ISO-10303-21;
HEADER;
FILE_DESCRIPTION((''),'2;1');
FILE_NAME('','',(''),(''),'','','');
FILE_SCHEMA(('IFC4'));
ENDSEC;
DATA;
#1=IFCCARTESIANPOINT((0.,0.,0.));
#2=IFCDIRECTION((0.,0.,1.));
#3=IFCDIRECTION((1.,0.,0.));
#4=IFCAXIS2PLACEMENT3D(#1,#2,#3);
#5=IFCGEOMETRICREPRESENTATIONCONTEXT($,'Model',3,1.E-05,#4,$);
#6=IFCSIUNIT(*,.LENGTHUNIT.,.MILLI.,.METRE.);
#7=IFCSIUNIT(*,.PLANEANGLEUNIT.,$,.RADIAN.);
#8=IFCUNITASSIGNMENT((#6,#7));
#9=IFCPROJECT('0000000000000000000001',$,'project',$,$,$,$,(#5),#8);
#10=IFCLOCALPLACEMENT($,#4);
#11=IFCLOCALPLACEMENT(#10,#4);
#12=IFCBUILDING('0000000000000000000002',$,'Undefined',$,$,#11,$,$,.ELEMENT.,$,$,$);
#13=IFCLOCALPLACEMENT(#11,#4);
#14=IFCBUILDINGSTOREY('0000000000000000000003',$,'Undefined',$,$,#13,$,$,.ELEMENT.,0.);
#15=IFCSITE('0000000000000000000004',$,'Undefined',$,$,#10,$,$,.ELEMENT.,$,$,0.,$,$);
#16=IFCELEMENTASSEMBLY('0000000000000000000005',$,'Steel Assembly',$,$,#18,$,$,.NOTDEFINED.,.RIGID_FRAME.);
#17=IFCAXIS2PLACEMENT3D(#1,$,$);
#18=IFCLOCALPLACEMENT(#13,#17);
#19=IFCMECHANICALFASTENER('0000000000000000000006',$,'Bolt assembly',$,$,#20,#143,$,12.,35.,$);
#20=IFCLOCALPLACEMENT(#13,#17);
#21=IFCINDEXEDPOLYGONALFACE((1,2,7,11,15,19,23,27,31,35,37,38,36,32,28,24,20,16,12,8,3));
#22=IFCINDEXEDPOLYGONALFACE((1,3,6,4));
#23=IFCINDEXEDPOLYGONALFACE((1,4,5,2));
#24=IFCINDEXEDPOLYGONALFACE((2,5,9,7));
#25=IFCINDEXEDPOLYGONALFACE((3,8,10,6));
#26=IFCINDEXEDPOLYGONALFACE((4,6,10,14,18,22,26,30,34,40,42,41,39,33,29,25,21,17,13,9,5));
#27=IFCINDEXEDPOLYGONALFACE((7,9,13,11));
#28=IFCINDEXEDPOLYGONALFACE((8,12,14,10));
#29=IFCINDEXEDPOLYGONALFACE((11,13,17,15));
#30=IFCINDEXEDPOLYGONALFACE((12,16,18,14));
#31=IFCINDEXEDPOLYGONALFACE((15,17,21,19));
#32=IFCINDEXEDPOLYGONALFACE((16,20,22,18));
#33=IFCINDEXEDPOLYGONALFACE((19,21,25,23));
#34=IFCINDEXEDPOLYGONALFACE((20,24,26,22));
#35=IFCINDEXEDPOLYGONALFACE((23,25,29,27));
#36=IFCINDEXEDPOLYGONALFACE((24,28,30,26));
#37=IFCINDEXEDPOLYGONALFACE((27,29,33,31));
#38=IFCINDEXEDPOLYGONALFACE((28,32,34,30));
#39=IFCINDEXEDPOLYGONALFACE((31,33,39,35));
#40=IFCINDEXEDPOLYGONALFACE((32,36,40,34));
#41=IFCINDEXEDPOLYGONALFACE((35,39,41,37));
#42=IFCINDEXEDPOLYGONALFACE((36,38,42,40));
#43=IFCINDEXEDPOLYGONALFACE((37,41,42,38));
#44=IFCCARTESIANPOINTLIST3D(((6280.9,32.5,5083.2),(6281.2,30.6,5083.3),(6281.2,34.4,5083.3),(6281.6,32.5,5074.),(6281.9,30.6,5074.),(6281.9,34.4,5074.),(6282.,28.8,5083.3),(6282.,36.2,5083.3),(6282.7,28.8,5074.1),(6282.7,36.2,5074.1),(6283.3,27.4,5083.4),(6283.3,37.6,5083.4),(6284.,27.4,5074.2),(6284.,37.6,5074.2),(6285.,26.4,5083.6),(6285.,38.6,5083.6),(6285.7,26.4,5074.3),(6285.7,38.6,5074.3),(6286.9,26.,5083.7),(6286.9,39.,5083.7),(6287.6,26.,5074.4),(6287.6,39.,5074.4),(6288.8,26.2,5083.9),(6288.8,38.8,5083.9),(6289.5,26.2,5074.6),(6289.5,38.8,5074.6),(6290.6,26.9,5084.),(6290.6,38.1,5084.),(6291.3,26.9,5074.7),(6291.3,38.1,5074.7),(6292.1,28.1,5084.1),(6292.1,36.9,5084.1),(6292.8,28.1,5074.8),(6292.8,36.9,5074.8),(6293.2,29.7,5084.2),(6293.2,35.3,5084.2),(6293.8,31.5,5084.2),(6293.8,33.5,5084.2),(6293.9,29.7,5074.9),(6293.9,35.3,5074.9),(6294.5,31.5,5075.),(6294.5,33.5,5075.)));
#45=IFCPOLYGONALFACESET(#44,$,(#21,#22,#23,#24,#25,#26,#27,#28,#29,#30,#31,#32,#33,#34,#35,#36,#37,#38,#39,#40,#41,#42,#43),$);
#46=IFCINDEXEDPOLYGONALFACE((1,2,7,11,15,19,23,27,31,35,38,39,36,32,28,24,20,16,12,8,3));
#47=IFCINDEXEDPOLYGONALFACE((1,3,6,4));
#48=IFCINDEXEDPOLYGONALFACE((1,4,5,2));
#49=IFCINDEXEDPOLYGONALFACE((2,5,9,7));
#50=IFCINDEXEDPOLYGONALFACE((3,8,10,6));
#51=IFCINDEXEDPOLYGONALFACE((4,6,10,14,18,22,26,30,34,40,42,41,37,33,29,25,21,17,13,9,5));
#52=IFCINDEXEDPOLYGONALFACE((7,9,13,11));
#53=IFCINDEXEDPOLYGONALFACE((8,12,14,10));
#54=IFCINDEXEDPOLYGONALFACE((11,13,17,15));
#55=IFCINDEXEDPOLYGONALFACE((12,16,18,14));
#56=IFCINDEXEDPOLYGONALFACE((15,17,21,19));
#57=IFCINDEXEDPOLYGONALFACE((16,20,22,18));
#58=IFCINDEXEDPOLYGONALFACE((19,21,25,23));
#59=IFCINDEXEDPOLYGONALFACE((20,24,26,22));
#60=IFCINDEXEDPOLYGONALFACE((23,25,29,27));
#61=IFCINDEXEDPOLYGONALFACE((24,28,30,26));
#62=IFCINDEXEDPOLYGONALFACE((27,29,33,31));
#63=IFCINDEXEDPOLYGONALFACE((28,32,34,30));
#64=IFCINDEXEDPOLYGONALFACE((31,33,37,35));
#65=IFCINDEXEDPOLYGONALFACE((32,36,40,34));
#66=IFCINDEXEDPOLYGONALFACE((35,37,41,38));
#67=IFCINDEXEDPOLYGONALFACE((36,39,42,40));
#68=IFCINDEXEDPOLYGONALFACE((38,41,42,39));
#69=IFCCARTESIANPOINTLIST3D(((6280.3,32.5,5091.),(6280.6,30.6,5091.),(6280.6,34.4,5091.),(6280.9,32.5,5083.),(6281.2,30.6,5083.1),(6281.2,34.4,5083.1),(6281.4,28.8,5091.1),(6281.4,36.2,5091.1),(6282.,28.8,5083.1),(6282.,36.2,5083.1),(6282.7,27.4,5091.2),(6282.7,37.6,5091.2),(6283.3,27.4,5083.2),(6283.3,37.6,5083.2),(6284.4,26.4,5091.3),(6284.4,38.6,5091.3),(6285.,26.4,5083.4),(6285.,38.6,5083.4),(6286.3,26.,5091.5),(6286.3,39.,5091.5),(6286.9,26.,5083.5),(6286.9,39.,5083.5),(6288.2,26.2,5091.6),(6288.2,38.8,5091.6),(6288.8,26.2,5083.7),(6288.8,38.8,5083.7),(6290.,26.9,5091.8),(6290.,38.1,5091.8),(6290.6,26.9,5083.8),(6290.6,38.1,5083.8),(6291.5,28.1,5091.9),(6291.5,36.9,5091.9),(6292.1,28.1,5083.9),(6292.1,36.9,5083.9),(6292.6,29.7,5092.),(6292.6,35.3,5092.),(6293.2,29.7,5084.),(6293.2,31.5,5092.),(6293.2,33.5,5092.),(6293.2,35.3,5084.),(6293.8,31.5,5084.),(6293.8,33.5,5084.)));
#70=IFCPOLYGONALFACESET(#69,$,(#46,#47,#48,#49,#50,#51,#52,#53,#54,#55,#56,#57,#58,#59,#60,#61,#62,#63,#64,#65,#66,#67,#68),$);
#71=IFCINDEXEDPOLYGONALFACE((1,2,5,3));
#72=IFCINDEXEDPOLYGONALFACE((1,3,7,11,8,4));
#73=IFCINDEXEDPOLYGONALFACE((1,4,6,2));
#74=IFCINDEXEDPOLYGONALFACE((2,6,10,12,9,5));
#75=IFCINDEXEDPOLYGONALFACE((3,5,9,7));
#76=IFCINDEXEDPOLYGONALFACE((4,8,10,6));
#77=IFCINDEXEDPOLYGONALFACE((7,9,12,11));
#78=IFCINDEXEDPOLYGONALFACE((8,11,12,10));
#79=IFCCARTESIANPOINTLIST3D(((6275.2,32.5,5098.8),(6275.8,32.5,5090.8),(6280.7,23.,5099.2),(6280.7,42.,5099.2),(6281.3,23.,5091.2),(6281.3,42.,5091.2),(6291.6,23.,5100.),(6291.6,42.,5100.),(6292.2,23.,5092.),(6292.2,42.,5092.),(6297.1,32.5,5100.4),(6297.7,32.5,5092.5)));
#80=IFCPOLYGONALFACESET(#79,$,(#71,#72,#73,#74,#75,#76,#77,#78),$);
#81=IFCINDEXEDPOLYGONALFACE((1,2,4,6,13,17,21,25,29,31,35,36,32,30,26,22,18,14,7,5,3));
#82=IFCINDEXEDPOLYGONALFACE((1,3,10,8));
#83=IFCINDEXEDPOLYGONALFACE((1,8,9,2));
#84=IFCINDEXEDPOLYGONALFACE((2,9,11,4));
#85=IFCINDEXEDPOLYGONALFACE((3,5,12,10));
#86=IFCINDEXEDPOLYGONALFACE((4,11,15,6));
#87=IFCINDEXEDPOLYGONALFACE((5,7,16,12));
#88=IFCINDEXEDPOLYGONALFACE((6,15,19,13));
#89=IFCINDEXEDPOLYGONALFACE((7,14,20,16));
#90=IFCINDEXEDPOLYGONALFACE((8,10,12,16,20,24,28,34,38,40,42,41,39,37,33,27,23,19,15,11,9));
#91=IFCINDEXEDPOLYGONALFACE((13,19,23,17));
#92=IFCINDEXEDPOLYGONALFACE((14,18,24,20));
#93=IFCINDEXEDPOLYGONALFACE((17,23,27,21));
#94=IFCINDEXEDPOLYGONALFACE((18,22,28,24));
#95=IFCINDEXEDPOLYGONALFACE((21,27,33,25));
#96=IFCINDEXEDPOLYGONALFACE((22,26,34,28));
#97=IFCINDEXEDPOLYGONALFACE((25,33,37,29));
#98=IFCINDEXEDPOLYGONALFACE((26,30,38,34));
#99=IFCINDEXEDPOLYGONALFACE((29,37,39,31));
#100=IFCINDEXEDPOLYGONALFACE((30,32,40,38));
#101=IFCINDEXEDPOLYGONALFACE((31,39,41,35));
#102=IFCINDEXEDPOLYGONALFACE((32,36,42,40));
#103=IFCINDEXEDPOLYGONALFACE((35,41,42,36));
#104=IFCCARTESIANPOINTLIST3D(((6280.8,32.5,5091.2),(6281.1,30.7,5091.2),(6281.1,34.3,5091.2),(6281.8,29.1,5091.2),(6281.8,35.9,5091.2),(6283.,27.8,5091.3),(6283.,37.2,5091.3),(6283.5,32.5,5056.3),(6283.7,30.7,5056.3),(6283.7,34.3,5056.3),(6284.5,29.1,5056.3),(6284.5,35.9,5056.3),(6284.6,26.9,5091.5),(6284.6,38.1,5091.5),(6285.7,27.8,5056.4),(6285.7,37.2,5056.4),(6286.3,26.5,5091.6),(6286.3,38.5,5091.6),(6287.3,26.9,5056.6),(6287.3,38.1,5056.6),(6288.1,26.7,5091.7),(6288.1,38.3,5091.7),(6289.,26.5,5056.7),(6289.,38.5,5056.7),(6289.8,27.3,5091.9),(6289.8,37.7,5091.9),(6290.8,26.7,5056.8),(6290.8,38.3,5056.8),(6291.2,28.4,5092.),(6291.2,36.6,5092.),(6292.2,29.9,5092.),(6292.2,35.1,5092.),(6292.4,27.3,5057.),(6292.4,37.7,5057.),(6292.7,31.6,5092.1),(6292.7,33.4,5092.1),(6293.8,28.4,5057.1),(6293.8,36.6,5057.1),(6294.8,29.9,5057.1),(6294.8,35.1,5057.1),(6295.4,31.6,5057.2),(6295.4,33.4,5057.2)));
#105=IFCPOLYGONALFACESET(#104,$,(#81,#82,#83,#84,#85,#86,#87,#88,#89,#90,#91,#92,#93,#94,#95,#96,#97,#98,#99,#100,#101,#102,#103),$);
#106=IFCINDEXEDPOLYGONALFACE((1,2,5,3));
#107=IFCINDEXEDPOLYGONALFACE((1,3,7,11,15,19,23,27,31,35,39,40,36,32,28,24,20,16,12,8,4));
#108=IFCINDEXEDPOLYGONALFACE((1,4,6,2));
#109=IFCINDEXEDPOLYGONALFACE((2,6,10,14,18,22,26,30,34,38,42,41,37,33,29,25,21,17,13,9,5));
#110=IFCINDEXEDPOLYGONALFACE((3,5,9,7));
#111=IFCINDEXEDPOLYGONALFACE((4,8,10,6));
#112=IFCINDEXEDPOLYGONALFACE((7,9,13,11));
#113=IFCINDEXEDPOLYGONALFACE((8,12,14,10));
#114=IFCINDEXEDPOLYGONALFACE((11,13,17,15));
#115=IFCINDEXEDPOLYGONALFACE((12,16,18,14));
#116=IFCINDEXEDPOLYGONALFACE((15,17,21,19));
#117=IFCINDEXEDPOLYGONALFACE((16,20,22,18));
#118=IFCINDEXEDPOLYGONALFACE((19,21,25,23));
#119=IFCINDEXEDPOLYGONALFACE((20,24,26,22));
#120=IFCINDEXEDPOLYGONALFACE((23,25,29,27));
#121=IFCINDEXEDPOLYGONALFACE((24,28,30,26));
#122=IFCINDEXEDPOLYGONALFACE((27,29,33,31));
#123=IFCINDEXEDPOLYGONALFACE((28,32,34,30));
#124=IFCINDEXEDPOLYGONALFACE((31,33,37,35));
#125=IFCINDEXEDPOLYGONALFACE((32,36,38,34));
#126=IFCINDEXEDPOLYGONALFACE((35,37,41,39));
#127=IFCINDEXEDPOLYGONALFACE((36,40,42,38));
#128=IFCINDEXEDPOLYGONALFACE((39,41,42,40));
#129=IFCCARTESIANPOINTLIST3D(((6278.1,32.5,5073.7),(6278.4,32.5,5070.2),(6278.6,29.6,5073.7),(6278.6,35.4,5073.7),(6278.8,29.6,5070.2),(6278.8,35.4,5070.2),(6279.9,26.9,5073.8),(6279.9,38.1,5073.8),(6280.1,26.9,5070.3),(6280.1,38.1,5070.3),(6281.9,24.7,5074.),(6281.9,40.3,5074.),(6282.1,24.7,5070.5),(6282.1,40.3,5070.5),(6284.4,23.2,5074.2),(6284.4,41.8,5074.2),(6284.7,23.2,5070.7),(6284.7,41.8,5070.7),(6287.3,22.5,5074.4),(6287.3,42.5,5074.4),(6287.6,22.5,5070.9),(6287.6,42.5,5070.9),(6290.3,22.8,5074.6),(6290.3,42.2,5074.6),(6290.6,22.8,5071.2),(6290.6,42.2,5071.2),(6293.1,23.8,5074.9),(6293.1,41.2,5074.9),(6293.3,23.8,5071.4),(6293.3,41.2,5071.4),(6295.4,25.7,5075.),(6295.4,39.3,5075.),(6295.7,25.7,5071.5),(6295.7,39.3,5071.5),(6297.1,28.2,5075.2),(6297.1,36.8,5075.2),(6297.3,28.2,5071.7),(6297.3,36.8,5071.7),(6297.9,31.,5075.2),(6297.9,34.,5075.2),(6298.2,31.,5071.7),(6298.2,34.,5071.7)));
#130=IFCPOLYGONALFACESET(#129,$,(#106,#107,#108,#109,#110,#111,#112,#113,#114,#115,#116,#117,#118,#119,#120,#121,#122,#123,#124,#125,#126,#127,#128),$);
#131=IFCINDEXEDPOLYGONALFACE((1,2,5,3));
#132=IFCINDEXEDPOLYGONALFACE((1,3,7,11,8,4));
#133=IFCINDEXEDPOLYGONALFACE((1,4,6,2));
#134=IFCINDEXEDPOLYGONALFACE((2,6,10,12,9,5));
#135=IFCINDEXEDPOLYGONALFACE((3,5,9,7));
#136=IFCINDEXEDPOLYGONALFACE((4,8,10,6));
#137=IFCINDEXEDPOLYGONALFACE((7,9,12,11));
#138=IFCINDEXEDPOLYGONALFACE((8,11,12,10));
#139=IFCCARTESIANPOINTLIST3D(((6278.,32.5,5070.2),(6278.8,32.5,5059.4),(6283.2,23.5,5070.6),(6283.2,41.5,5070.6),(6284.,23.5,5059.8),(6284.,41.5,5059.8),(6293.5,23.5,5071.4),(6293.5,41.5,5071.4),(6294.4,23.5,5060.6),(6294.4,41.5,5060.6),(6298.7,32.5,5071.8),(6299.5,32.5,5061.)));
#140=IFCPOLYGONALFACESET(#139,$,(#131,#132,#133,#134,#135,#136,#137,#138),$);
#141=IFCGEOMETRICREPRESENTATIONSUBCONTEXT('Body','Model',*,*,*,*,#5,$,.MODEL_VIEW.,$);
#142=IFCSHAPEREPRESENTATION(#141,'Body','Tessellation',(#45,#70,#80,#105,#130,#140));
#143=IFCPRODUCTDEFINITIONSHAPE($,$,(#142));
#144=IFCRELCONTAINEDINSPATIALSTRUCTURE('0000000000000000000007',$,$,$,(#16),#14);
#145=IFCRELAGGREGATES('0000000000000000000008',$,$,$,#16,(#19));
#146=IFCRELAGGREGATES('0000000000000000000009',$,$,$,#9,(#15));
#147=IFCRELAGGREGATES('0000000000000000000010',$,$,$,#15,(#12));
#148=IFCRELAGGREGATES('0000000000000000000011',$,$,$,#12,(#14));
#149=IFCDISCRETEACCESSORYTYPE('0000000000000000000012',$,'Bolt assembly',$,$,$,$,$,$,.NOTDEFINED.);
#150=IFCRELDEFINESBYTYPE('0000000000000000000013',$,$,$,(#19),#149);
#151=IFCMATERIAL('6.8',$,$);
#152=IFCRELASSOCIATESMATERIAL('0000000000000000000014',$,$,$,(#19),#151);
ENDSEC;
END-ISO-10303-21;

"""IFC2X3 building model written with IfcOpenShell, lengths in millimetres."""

from ifc_helpers import new_model, si_unit, frame, origin_with_axes, origin_2d_with_axis, place, context, subcontext, project, spatial, polyline, circle, outline, extrude, source, transform, mapped, material, type_object, element, aggregate, save


model = new_model("IFC2X3")

# Units and contexts
model_context = context("Model", 3, precision=1e-05, world=origin_with_axes())
body_context = subcontext(model_context, "Body", "Model", "MODEL_VIEW")
ifc_project = project(units=[si_unit("LENGTHUNIT", "METRE", prefix="MILLI"), si_unit("PLANEANGLEUNIT", "RADIAN")], contexts=[model_context])

# Site, building, storey
site_placement = place(None, origin_with_axes())
site = spatial("IfcSite", under=ifc_project, at=site_placement, Name="Undefined", CompositionType="ELEMENT", RefElevation=0.0)
building_placement = place(site_placement, origin_with_axes())
building = spatial("IfcBuilding", under=site, at=building_placement, Name="Undefined", CompositionType="ELEMENT")
storey_placement = place(building_placement, origin_with_axes())
storey = spatial("IfcBuildingStorey", under=building, at=storey_placement, Name="Undefined", CompositionType="ELEMENT", Elevation=0.0)

# Element assembly, mechanical fastener
ifc_material_1 = material(Name="6.8")
discrete_accessory_type_1 = type_object("IfcDiscreteAccessoryType", Name="Bolt assembly")
shared_shape_1 = source(origin_with_axes(), body_context, "Body", "SweptSolid", [
    extrude(circle(Radius=6.5, at=origin_2d_with_axis()), frame((0.0, -0.1, 0.0), z_axis=(0.0, 1.0, 0.0), x_axis=(1.0, 0.0, 0.0)), (0.0, 0.0, 1.0), 9.3),
    extrude(circle(Radius=6.5, at=origin_2d_with_axis()), frame((0.0, -7.9, 0.0), z_axis=(0.0, 1.0, 0.0), x_axis=(1.0, 0.0, 0.0)), (0.0, 0.0, 1.0), 8.0),
    extrude(outline(polyline([(11.0, 0.0), (5.5, 9.5), (-5.5, 9.5), (-11.0, 0.0), (-5.5, -9.5), (5.5, -9.5), (11.0, 0.0)])), frame((0.0, -16.0, 0.0), z_axis=(0.0, 1.0, 0.0), x_axis=(1.0, 0.0, 0.0)), (0.0, 0.0, 1.0), 8.0),
    extrude(circle(Radius=6.0, at=origin_2d_with_axis()), frame((0.0, -8.0, 0.0), z_axis=(0.0, 1.0, 0.0), x_axis=(1.0, 0.0, 0.0)), (0.0, 0.0, 1.0), 35.0),
    extrude(circle(Radius=10.0, at=origin_2d_with_axis()), frame((0.0, 9.2, 0.0), z_axis=(0.0, 1.0, 0.0), x_axis=(1.0, 0.0, 0.0)), (0.0, 0.0, 1.0), 3.5),
    extrude(outline(polyline([(10.4, 0.0), (5.2, 9.0), (-5.2, 9.0), (-10.4, 0.0), (-5.2, -9.0), (5.2, -9.0), (10.4, 0.0)])), frame((0.0, 12.7, 0.0), z_axis=(0.0, 1.0, 0.0), x_axis=(1.0, 0.0, 0.0)), (0.0, 0.0, 1.0), 10.8),
])
assembly_1_placement = place(storey_placement, origin_with_axes())
assembly_1 = element("IfcElementAssembly", 1, at=assembly_1_placement, inside=storey, Name="Steel Assembly", AssemblyPlace="NOTDEFINED", PredefinedType="RIGID_FRAME")
mechanical_fastener_1_placement = place(assembly_1_placement, frame((6287.4, 32.5, 5083.6), z_axis=(0.0, -1.0, 0.0), x_axis=(-0.997054, 0.0, -0.076696)))
mechanical_fastener_1 = element("IfcMechanicalFastener", 2, at=mechanical_fastener_1_placement, type_object=discrete_accessory_type_1, material=ifc_material_1, Name="Bolt assembly", NominalDiameter=12.0, NominalLength=35.0, context=body_context, shape_type="MappedRepresentation", body=[
    mapped(shared_shape_1, transform((0.0, 0.0, 0.0))),
])
aggregate(assembly_1, [mechanical_fastener_1])

save(model, "model.ifc")
